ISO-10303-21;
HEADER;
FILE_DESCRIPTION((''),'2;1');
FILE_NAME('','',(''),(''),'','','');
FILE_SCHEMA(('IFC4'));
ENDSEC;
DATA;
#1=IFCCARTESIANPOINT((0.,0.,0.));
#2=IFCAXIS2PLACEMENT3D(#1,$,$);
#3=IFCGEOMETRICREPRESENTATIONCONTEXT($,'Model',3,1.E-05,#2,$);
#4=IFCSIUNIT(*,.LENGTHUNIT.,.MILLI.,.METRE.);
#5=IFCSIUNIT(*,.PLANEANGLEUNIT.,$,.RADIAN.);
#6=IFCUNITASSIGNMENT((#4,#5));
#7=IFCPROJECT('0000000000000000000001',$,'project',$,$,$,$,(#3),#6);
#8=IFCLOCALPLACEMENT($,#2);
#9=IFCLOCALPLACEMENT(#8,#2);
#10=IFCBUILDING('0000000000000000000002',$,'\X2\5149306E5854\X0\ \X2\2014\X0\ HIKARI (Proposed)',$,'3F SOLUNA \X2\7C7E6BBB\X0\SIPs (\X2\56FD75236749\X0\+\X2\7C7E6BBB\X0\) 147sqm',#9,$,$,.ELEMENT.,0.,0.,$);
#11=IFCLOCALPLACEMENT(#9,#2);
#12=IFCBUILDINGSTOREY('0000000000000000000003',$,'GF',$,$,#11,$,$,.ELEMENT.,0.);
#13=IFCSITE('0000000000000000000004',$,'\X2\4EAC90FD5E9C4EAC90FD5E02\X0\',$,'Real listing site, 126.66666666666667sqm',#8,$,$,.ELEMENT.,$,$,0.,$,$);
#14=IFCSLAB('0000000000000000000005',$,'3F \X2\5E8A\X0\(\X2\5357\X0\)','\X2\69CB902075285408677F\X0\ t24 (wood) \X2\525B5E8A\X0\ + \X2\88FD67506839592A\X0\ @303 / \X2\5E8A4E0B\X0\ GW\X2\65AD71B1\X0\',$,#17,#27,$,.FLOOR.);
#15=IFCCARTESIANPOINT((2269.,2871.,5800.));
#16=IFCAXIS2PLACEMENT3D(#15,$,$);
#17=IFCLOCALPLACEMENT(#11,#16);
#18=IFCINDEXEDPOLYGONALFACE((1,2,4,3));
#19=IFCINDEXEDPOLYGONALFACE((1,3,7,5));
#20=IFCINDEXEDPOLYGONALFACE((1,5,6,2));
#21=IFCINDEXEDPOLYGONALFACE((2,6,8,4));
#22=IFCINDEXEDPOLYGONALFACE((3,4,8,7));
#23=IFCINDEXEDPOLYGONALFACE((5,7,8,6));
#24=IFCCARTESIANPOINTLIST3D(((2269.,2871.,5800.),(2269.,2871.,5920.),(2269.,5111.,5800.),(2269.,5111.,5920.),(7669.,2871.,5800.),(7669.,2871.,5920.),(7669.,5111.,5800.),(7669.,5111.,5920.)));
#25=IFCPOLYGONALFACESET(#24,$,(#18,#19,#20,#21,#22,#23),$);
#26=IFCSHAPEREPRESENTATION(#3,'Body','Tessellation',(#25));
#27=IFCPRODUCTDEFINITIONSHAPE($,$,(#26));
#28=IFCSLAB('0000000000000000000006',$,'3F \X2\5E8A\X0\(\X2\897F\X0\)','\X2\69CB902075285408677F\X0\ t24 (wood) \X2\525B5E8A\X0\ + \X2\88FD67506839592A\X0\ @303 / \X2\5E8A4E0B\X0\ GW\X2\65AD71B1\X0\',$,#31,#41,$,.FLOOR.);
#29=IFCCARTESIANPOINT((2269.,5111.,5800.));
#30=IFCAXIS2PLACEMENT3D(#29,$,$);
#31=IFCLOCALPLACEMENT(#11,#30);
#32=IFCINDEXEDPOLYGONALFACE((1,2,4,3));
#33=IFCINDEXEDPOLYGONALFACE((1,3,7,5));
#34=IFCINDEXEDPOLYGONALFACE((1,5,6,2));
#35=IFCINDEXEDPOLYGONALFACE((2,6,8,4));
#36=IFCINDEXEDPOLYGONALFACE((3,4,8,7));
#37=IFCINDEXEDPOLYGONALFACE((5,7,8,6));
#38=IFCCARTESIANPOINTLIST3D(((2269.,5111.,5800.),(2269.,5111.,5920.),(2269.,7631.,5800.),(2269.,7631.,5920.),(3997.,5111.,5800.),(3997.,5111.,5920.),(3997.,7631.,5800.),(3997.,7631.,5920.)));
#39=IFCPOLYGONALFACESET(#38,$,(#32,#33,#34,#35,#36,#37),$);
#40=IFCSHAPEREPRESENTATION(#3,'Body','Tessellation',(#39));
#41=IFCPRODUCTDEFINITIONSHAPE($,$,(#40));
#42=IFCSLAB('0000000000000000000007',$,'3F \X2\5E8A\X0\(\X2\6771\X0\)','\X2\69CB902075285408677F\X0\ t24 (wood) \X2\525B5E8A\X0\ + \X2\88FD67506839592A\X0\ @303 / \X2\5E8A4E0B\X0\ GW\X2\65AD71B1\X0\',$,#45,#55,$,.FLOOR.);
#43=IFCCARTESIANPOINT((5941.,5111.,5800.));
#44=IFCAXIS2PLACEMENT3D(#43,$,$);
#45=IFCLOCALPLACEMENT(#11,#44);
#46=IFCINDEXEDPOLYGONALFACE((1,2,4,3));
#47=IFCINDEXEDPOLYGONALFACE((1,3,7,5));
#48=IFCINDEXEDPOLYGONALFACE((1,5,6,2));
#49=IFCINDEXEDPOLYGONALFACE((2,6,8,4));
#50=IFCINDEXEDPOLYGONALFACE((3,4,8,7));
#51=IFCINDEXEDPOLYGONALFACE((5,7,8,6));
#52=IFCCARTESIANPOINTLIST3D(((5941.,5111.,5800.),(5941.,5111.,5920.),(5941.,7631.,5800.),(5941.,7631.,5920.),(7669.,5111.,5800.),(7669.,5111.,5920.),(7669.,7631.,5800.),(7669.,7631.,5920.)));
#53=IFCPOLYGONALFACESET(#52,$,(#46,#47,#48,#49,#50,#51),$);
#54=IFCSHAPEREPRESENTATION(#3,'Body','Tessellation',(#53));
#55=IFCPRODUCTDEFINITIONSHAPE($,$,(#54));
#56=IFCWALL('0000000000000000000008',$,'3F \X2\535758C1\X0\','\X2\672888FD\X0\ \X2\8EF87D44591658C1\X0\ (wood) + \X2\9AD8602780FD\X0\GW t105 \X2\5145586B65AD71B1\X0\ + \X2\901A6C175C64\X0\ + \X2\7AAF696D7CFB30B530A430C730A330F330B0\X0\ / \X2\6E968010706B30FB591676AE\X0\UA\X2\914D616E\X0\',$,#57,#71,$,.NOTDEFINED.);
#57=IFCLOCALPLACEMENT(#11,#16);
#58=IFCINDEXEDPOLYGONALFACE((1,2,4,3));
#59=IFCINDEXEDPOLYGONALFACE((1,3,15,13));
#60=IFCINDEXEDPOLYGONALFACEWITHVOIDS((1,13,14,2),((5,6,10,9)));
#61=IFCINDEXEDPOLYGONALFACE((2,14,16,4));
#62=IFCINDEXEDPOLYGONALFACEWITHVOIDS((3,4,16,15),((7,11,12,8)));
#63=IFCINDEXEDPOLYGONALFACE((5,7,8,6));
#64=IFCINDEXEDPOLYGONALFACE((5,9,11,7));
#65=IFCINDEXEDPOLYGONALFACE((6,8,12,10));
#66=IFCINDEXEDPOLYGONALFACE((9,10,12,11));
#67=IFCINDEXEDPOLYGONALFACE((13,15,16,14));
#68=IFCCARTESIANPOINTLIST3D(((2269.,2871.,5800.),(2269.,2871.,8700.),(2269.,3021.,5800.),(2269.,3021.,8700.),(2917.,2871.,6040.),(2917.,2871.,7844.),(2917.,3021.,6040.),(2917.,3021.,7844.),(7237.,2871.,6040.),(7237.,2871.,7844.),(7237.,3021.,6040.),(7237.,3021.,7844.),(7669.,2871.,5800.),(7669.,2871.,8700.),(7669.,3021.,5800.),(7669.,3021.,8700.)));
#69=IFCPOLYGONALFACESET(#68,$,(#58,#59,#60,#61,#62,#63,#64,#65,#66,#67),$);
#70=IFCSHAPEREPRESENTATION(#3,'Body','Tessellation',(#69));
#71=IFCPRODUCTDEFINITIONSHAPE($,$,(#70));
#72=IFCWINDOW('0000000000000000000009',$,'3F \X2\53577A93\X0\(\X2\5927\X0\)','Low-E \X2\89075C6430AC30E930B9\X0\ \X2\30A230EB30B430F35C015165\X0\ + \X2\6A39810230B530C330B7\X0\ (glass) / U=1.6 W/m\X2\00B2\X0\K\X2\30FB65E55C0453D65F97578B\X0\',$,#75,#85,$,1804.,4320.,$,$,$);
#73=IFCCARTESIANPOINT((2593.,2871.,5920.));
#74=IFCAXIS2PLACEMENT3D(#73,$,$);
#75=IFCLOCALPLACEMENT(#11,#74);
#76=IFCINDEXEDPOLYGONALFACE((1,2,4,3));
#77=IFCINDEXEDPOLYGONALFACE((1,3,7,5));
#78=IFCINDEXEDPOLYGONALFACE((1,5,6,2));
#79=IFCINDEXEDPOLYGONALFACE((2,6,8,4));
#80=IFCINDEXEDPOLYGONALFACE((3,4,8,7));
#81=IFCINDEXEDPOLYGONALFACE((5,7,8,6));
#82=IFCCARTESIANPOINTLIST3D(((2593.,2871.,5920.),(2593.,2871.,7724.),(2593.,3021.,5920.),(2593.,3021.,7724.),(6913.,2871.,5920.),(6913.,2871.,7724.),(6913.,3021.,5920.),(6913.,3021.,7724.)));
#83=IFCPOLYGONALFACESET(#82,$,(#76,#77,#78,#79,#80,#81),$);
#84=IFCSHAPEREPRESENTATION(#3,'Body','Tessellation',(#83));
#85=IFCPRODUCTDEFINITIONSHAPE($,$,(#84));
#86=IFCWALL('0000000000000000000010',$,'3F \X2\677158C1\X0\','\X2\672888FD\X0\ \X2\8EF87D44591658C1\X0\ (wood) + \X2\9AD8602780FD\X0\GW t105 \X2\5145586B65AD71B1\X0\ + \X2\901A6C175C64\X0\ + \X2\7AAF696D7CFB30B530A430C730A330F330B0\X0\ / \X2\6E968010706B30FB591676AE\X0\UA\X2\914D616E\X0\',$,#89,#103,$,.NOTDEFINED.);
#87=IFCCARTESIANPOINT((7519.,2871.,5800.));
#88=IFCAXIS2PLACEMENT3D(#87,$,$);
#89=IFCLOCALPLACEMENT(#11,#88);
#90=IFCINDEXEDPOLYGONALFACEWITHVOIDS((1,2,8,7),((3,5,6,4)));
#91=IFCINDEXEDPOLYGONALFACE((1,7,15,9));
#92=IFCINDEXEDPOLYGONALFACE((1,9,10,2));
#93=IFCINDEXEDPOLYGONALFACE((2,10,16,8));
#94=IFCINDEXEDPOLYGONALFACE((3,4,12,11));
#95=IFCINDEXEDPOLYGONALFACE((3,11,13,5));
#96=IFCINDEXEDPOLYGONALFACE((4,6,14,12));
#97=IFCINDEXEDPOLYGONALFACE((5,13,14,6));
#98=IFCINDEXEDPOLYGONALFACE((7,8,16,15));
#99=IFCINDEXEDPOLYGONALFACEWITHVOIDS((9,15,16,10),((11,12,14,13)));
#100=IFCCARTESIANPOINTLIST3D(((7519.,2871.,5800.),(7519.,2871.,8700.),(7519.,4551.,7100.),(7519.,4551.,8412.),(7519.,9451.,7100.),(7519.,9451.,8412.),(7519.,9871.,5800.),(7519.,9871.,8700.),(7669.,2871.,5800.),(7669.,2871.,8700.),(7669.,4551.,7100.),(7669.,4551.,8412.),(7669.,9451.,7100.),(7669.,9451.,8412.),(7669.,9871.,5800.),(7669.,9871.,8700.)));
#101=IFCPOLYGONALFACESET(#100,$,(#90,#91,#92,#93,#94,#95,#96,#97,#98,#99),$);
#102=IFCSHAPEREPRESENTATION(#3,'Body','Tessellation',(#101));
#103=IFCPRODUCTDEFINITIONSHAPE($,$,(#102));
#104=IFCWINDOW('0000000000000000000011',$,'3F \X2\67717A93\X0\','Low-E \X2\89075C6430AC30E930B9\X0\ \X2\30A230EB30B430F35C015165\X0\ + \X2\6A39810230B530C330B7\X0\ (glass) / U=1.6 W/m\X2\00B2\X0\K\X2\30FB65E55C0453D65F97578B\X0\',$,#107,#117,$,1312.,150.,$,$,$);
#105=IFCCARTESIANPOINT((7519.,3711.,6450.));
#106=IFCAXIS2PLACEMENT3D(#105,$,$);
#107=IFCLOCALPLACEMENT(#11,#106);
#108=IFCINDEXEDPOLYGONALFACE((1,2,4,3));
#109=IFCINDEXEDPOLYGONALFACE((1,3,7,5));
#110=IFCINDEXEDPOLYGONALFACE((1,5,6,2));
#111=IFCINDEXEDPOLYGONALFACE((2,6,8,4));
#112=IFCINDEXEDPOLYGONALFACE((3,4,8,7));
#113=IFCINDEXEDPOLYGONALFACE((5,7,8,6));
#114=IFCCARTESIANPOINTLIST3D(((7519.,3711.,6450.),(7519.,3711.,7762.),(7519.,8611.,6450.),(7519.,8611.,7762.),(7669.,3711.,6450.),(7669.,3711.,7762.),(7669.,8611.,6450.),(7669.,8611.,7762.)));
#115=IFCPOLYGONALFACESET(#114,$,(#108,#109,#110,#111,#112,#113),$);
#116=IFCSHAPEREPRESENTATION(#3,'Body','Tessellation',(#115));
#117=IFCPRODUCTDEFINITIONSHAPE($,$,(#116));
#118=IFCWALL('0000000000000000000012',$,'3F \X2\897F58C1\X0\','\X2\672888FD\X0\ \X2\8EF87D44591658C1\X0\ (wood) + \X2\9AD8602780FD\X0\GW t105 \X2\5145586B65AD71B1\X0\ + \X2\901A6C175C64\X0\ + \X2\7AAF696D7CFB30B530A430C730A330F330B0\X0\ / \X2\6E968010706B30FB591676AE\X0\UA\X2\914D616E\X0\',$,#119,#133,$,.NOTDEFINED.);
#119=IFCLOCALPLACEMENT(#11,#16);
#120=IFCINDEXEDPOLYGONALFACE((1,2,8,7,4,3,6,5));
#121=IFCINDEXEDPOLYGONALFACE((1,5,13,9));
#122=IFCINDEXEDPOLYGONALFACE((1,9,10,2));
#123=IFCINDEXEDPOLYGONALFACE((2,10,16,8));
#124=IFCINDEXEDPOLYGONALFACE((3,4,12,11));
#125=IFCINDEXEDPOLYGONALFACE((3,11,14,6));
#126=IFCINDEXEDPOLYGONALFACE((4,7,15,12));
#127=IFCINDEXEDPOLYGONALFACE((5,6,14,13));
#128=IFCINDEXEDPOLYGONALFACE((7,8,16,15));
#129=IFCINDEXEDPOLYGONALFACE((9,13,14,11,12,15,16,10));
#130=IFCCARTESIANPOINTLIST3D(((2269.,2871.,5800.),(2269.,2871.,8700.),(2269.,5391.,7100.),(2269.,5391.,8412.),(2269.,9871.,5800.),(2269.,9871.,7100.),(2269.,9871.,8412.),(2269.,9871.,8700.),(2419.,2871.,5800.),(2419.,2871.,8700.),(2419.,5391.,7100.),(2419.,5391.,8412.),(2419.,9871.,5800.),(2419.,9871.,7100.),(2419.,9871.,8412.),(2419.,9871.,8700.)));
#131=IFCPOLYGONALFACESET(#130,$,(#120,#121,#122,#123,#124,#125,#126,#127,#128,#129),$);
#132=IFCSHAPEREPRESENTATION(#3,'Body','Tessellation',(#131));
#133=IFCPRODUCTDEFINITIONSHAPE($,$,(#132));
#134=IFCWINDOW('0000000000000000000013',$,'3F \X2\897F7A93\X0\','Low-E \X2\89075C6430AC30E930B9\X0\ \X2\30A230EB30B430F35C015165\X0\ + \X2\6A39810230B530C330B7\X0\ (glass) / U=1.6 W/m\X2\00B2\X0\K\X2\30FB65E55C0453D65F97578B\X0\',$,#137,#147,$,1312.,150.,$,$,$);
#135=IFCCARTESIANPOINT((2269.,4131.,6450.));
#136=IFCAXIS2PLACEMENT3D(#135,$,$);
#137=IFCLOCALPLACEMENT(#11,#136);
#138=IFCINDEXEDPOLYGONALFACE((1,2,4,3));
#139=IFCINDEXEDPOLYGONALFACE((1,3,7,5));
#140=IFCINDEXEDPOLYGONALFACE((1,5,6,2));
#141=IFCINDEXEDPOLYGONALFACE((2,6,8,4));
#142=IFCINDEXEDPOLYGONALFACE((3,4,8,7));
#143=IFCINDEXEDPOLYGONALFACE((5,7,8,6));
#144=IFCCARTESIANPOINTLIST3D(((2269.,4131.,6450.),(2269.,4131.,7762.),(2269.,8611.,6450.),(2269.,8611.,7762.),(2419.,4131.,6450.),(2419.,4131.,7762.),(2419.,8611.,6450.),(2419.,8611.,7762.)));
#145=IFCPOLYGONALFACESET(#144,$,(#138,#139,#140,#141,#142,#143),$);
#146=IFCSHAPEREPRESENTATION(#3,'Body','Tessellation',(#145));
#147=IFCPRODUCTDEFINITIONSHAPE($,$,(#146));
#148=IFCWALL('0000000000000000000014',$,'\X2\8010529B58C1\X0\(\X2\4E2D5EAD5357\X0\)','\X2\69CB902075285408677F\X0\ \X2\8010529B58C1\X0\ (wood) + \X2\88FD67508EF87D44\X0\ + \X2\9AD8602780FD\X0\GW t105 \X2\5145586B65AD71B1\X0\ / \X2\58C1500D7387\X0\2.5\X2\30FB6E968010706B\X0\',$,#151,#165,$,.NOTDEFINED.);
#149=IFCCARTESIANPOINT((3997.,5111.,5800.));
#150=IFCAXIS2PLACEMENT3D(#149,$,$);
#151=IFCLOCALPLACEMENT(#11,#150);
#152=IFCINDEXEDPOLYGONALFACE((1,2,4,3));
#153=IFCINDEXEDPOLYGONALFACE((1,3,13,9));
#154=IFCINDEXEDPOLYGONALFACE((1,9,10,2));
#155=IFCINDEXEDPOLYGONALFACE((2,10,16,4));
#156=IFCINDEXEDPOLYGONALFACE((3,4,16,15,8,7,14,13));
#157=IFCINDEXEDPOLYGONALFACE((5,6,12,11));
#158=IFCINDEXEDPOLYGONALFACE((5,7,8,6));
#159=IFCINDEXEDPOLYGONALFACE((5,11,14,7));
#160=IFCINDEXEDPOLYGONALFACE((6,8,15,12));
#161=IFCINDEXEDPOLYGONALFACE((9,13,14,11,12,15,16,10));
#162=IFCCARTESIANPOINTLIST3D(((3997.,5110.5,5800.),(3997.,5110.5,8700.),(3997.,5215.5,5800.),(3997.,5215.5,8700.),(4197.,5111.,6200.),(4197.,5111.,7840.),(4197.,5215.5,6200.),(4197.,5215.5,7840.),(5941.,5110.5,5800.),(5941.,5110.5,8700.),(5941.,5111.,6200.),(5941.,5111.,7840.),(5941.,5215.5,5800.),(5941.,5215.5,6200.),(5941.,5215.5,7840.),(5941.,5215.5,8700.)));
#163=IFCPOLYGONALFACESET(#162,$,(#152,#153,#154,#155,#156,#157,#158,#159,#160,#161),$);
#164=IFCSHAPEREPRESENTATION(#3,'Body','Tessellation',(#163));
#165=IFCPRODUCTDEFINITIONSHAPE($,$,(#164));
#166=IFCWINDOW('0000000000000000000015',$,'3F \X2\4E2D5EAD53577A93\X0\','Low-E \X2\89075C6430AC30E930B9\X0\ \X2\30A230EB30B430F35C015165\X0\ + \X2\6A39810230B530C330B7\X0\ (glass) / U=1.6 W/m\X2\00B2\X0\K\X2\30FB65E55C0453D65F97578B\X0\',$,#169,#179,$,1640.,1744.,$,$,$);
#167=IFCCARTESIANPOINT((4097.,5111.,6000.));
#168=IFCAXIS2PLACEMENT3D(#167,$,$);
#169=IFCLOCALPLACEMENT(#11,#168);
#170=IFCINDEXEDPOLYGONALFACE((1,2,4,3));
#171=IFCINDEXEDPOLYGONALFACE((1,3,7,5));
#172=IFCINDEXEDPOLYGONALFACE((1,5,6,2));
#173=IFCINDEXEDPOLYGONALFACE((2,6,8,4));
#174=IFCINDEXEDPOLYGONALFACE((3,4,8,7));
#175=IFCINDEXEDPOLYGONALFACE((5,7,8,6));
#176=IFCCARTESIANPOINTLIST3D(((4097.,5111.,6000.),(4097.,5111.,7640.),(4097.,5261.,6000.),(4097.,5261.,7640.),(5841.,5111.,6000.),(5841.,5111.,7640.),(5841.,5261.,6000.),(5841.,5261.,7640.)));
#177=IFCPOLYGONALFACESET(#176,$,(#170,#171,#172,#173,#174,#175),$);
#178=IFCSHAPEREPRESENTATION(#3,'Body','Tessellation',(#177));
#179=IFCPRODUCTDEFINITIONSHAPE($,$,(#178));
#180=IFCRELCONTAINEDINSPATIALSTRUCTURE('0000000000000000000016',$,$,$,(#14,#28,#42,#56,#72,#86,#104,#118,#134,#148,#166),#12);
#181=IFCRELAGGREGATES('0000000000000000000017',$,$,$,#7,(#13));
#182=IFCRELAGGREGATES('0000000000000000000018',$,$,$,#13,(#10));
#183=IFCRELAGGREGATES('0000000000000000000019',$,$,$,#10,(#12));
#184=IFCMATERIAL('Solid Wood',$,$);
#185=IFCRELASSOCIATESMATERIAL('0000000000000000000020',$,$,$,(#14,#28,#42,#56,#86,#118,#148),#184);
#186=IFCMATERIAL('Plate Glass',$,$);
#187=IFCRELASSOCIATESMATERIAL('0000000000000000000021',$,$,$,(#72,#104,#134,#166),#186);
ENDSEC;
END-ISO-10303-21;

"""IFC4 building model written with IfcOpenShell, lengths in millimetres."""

from ifc_helpers import new_model, si_unit, frame, frame_2d, origin, place, context, project, spatial, rectangle, extrude, material, element, fill, save


model = new_model("IFC4")

# Units and contexts
model_context = context("Model", 3, precision=1e-05, world=origin())
ifc_project = project(units=[si_unit("LENGTHUNIT", "METRE", prefix="MILLI"), si_unit("PLANEANGLEUNIT", "RADIAN")], contexts=[model_context])

# Site, building, storey
site_placement = place(None, origin())
site = spatial("IfcSite", under=ifc_project, at=site_placement, Name="京都府京都市", ObjectType="Real listing site, 126.66666666666667sqm", CompositionType="ELEMENT", RefElevation=0.0)
building_placement = place(site_placement, origin())
building = spatial("IfcBuilding", under=site, at=building_placement, Name="光の塔 — HIKARI (Proposed)", ObjectType="3F SOLUNA 籾殻SIPs (国産杉+籾殻) 147sqm", CompositionType="ELEMENT", ElevationOfRefHeight=0.0, ElevationOfTerrain=0.0)
storey_placement = place(building_placement, origin())
storey = spatial("IfcBuildingStorey", under=building, at=storey_placement, Name="GF", CompositionType="ELEMENT", Elevation=0.0)

# Slabs
ifc_material_1 = material(Name="Solid Wood")
slab_1_placement = place(storey_placement, frame((2269.0, 2871.0, 5800.0)))
element("IfcSlab", 1, at=slab_1_placement, inside=storey, material=ifc_material_1, Name="3F 床(南)", Description="構造用合板 t24 (wood) 剛床 + 製材根太 @303 / 床下 GW断熱", PredefinedType="FLOOR", context=model_context, shape_type="SweptSolid", body=[
    extrude(rectangle(XDim=5400.0, YDim=2240.0, at=frame_2d((2700.0, 1120.0))), frame((2269.0, 2871.0, 5800.0)), (0.0, 0.0, 1.0), 120.0),
])
slab_2_placement = place(storey_placement, frame((2269.0, 5111.0, 5800.0)))
element("IfcSlab", 2, at=slab_2_placement, inside=storey, material=ifc_material_1, Name="3F 床(西)", Description="構造用合板 t24 (wood) 剛床 + 製材根太 @303 / 床下 GW断熱", PredefinedType="FLOOR", context=model_context, shape_type="SweptSolid", body=[
    extrude(rectangle(XDim=1728.0, YDim=2520.0, at=frame_2d((864.0, 1260.0))), frame((2269.0, 5111.0, 5800.0)), (0.0, 0.0, 1.0), 120.0),
])
slab_3_placement = place(storey_placement, frame((5941.0, 5111.0, 5800.0)))
element("IfcSlab", 3, at=slab_3_placement, inside=storey, material=ifc_material_1, Name="3F 床(東)", Description="構造用合板 t24 (wood) 剛床 + 製材根太 @303 / 床下 GW断熱", PredefinedType="FLOOR", context=model_context, shape_type="SweptSolid", body=[
    extrude(rectangle(XDim=1728.0, YDim=2520.0, at=frame_2d((864.0, 1260.0))), frame((5941.0, 5111.0, 5800.0)), (0.0, 0.0, 1.0), 120.0),
])

# Walls, openings, windows
wall_1_placement = place(storey_placement, frame((2269.0, 2871.0, 5800.0)))
wall_1 = element("IfcWall", 4, at=wall_1_placement, inside=storey, material=ifc_material_1, Name="3F 南壁", Description="木製 軸組外壁 (wood) + 高性能GW t105 充填断熱 + 通気層 + 窯業系サイディング / 準耐火・外皮UA配慮", PredefinedType="NOTDEFINED", context=model_context, shape_type="SweptSolid", body=[
    extrude(rectangle(XDim=5400.0, YDim=150.0, at=frame_2d((2700.0, 75.0))), frame((2269.0, 2871.0, 5800.0)), (0.0, 0.0, 1.0), 2900.0),
])
opening_1_placement = place(storey_placement, frame((2593.0, 2871.0, 5920.0)))
opening_1 = element("IfcOpeningElement", 5, at=opening_1_placement, cuts=wall_1, PredefinedType="NOTDEFINED", context=model_context, shape_type="SweptSolid", body=[
    extrude(rectangle(XDim=4320.0, YDim=150.0, at=frame_2d((2160.0, 75.0))), frame((2593.0, 2871.0, 5920.0)), (0.0, 0.0, 1.0), 1804.0),
])
ifc_material_2 = material(Name="Plate Glass")
window_1_placement = place(storey_placement, frame((2593.0, 2871.0, 5920.0)))
window_1 = element("IfcWindow", 6, at=window_1_placement, inside=storey, material=ifc_material_2, Name="3F 南窓(大)", Description="Low-E 複層ガラス アルゴン封入 + 樹脂サッシ (glass) / U=1.6 W/m²K・日射取得型", OverallHeight=1804.0, OverallWidth=4320.0, context=model_context, shape_type="SweptSolid", body=[
    extrude(rectangle(XDim=4320.0, YDim=150.0, at=frame_2d((2160.0, 75.0))), frame((2593.0, 2871.0, 5920.0)), (0.0, 0.0, 1.0), 1804.0),
])
fill(opening_1, window_1)
wall_2_placement = place(storey_placement, frame((7519.0, 2871.0, 5800.0)))
wall_2 = element("IfcWall", 7, at=wall_2_placement, inside=storey, material=ifc_material_1, Name="3F 東壁", Description="木製 軸組外壁 (wood) + 高性能GW t105 充填断熱 + 通気層 + 窯業系サイディング / 準耐火・外皮UA配慮", PredefinedType="NOTDEFINED", context=model_context, shape_type="SweptSolid", body=[
    extrude(rectangle(XDim=150.0, YDim=7000.0, at=frame_2d((75.0, 3500.0))), frame((7519.0, 2871.0, 5800.0)), (0.0, 0.0, 1.0), 2900.0),
])
opening_2_placement = place(storey_placement, frame((7519.0, 3711.0, 6450.0)))
opening_2 = element("IfcOpeningElement", 8, at=opening_2_placement, cuts=wall_2, PredefinedType="NOTDEFINED", context=model_context, shape_type="SweptSolid", body=[
    extrude(rectangle(XDim=150.0, YDim=4900.0, at=frame_2d((75.0, 2450.0))), frame((7519.0, 3711.0, 6450.0)), (0.0, 0.0, 1.0), 1312.0),
])
window_2_placement = place(storey_placement, frame((7519.0, 3711.0, 6450.0)))
window_2 = element("IfcWindow", 9, at=window_2_placement, inside=storey, material=ifc_material_2, Name="3F 東窓", Description="Low-E 複層ガラス アルゴン封入 + 樹脂サッシ (glass) / U=1.6 W/m²K・日射取得型", OverallHeight=1312.0, OverallWidth=150.0, context=model_context, shape_type="SweptSolid", body=[
    extrude(rectangle(XDim=150.0, YDim=4900.0, at=frame_2d((75.0, 2450.0))), frame((7519.0, 3711.0, 6450.0)), (0.0, 0.0, 1.0), 1312.0),
])
fill(opening_2, window_2)
wall_3_placement = place(storey_placement, frame((2269.0, 2871.0, 5800.0)))
wall_3 = element("IfcWall", 10, at=wall_3_placement, inside=storey, material=ifc_material_1, Name="3F 西壁", Description="木製 軸組外壁 (wood) + 高性能GW t105 充填断熱 + 通気層 + 窯業系サイディング / 準耐火・外皮UA配慮", PredefinedType="NOTDEFINED", context=model_context, shape_type="SweptSolid", body=[
    extrude(rectangle(XDim=150.0, YDim=7000.0, at=frame_2d((75.0, 3500.0))), frame((2269.0, 2871.0, 5800.0)), (0.0, 0.0, 1.0), 2900.0),
])
opening_3_placement = place(storey_placement, frame((2269.0, 4131.0, 6450.0)))
opening_3 = element("IfcOpeningElement", 11, at=opening_3_placement, cuts=wall_3, PredefinedType="NOTDEFINED", context=model_context, shape_type="SweptSolid", body=[
    extrude(rectangle(XDim=150.0, YDim=4480.0, at=frame_2d((75.0, 2240.0))), frame((2269.0, 4131.0, 6450.0)), (0.0, 0.0, 1.0), 1312.0),
])
window_3_placement = place(storey_placement, frame((2269.0, 4131.0, 6450.0)))
window_3 = element("IfcWindow", 12, at=window_3_placement, inside=storey, material=ifc_material_2, Name="3F 西窓", Description="Low-E 複層ガラス アルゴン封入 + 樹脂サッシ (glass) / U=1.6 W/m²K・日射取得型", OverallHeight=1312.0, OverallWidth=150.0, context=model_context, shape_type="SweptSolid", body=[
    extrude(rectangle(XDim=150.0, YDim=4480.0, at=frame_2d((75.0, 2240.0))), frame((2269.0, 4131.0, 6450.0)), (0.0, 0.0, 1.0), 1312.0),
])
fill(opening_3, window_3)
wall_4_placement = place(storey_placement, frame((3997.0, 5111.0, 5800.0)))
wall_4 = element("IfcWall", 13, at=wall_4_placement, inside=storey, material=ifc_material_1, Name="耐力壁(中庭南)", Description="構造用合板 耐力壁 (wood) + 製材軸組 + 高性能GW t105 充填断熱 / 壁倍率2.5・準耐火", PredefinedType="NOTDEFINED", context=model_context, shape_type="SweptSolid", body=[
    extrude(rectangle(XDim=1944.0, YDim=105.0, at=frame_2d((972.0, 52.0))), frame((3997.0, 5111.0, 5800.0)), (0.0, 0.0, 1.0), 2900.0),
])
opening_4_placement = place(storey_placement, frame((4097.0, 5111.0, 6000.0)))
opening_4 = element("IfcOpeningElement", 14, at=opening_4_placement, cuts=wall_4, PredefinedType="NOTDEFINED", context=model_context, shape_type="SweptSolid", body=[
    extrude(rectangle(XDim=1744.0, YDim=150.0, at=frame_2d((872.0, 75.0))), frame((4097.0, 5111.0, 6000.0)), (0.0, 0.0, 1.0), 1640.0),
])
window_4_placement = place(storey_placement, frame((4097.0, 5111.0, 6000.0)))
window_4 = element("IfcWindow", 15, at=window_4_placement, inside=storey, material=ifc_material_2, Name="3F 中庭南窓", Description="Low-E 複層ガラス アルゴン封入 + 樹脂サッシ (glass) / U=1.6 W/m²K・日射取得型", OverallHeight=1640.0, OverallWidth=1744.0, context=model_context, shape_type="SweptSolid", body=[
    extrude(rectangle(XDim=1744.0, YDim=150.0, at=frame_2d((872.0, 75.0))), frame((4097.0, 5111.0, 6000.0)), (0.0, 0.0, 1.0), 1640.0),
])
fill(opening_4, window_4)

save(model, "model.ifc")
